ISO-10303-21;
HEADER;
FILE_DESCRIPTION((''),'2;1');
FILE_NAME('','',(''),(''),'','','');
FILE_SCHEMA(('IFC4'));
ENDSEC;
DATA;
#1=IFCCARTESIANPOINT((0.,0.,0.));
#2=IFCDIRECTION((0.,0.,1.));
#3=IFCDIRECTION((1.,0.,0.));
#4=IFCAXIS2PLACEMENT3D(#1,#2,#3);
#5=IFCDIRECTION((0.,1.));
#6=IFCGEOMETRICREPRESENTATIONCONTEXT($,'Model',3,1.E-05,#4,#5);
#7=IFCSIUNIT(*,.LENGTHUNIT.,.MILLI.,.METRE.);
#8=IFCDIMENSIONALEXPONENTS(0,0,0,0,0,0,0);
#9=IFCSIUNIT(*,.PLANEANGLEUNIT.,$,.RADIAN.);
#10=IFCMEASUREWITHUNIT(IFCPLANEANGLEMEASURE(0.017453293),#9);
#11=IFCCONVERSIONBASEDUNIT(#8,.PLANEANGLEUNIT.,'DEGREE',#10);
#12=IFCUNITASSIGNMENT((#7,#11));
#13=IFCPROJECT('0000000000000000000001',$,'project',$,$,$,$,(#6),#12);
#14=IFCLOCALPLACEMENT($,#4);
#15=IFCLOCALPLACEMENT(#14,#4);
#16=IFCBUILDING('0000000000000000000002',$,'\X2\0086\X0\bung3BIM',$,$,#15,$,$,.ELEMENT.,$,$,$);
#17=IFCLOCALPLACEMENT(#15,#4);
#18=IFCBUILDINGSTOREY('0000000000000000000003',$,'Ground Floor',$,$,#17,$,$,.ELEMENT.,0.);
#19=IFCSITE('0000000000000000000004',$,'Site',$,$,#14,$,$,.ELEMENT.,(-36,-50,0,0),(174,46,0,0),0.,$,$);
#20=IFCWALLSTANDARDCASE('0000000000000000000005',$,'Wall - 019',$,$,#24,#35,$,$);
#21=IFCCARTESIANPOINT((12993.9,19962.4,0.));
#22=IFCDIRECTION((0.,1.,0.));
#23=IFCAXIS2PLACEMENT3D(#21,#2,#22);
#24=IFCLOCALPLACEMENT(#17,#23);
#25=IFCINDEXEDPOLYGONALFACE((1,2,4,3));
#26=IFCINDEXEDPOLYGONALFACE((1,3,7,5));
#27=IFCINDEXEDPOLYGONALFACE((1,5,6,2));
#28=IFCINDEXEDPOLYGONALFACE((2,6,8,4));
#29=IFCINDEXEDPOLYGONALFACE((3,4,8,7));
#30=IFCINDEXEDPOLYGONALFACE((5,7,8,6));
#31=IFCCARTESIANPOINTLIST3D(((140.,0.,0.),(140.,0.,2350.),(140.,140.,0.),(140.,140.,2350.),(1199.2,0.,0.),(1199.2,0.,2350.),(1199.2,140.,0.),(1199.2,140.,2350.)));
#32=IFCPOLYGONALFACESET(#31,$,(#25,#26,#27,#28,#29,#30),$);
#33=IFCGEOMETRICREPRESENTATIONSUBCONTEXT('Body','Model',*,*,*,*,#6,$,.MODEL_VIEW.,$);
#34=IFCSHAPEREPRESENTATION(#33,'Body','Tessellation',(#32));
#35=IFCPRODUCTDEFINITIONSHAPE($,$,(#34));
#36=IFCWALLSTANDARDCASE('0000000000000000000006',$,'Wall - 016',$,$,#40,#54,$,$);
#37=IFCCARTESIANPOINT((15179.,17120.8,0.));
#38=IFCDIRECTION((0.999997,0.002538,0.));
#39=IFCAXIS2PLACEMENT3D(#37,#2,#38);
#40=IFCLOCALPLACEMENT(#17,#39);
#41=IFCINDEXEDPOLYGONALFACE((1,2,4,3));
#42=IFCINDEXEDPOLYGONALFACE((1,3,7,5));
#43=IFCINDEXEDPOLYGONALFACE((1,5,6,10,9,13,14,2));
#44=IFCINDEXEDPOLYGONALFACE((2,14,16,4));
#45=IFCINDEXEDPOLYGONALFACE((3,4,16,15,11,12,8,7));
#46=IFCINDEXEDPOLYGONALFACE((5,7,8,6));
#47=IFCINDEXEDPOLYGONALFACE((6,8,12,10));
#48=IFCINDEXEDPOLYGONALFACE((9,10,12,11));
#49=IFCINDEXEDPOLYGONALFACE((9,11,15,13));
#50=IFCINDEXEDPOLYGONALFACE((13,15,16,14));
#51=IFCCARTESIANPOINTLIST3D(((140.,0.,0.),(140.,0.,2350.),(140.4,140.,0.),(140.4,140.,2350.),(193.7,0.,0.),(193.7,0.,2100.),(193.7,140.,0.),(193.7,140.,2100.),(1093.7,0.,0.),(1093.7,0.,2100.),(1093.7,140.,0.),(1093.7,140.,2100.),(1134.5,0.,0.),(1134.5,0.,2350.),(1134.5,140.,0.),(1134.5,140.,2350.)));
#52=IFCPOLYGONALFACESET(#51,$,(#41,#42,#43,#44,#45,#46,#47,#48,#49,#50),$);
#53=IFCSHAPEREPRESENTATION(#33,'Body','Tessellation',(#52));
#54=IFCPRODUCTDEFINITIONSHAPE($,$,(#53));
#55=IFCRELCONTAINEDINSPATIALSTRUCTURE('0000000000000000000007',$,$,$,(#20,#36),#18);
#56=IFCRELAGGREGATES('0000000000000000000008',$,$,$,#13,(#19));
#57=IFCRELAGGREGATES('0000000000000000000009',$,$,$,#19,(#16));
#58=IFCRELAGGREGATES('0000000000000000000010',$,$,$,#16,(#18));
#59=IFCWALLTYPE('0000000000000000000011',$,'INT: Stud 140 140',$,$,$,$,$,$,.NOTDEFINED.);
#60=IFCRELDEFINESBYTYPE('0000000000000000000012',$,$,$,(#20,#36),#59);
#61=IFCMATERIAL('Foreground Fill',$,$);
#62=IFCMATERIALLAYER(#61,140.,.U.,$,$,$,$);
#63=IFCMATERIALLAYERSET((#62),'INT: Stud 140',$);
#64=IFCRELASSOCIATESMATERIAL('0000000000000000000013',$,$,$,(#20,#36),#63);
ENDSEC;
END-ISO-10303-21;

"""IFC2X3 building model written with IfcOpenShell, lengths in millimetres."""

from ifc_helpers import new_model, entity, si_unit, converted_unit, direction, frame, origin_with_axes, origin_2d_with_axis, place, context, subcontext, project, spatial, polyline, rectangle, outline, extrude, material, layer, layer_set, layer_usage, type_object, element, save


model = new_model("IFC2X3")

# Units and contexts
model_context = context("Model", 3, precision=1e-05, world=origin_with_axes(), true_north=direction((0.0, 1.0)))
body_context = subcontext(model_context, "Body", "Model", "MODEL_VIEW")
ifc_project = project(units=[si_unit("LENGTHUNIT", "METRE", prefix="MILLI"), converted_unit("PLANEANGLEUNIT", "DEGREE", entity("IfcPlaneAngleMeasure", 0.017453293), si_unit("PLANEANGLEUNIT", "RADIAN"), dimensions=[0, 0, 0, 0, 0, 0, 0])], contexts=[model_context])

# Site, building, storey
site_placement = place(None, origin_with_axes())
site = spatial("IfcSite", under=ifc_project, at=site_placement, Name="Site", CompositionType="ELEMENT", RefLatitude=(-36, -50, 0, 0), RefLongitude=(174, 46, 0, 0), RefElevation=0.0)
building_placement = place(site_placement, origin_with_axes())
building = spatial("IfcBuilding", under=site, at=building_placement, Name="\u0086bung3BIM", CompositionType="ELEMENT")
storey_placement = place(building_placement, origin_with_axes())
storey = spatial("IfcBuildingStorey", under=building, at=storey_placement, Name="Ground Floor", CompositionType="ELEMENT", Elevation=0.0)

# Shared definitions
ifc_material_1 = material(Name="Foreground Fill")
ifc_layer_1 = layer(ifc_material_1, 140.0, ventilated="UNKNOWN")
ifc_layer_set_1 = layer_set([ifc_layer_1], Name="INT: Stud 140")
wall_type_1 = type_object("IfcWallType", Name="INT: Stud 140 140", PredefinedType="NOTDEFINED")

# Wall
ifc_layer_usage_1 = layer_usage(ifc_layer_set_1, "AXIS2", "POSITIVE", 0.0)
wall_1_placement = place(storey_placement, frame((12993.9, 19962.4, 0.0), z_axis=(0.0, 0.0, 1.0), x_axis=(0.0, 1.0, 0.0)))
element("IfcWallStandardCase", 1, at=wall_1_placement, inside=storey, type_object=wall_type_1, material=ifc_layer_usage_1, Name="Wall - 019", context=body_context, shape_type="SweptSolid", body=[
    extrude(outline(polyline([(140.0, 0.0), (1199.2, 0.0), (1199.2, 140.0), (140.0, 140.0), (140.0, 0.0)])), origin_with_axes(), (0.0, 0.0, 1.0), 2350.0),
])

# Wall, opening
ifc_layer_usage_2 = layer_usage(ifc_layer_set_1, "AXIS2", "POSITIVE", 0.0)
wall_2_placement = place(storey_placement, frame((15179.0, 17120.8, 0.0), z_axis=(0.0, 0.0, 1.0), x_axis=(0.999997, 0.002538, 0.0)))
wall_2 = element("IfcWallStandardCase", 2, at=wall_2_placement, inside=storey, type_object=wall_type_1, material=ifc_layer_usage_2, Name="Wall - 016", context=body_context, shape_type="SweptSolid", body=[
    extrude(outline(polyline([(140.0, 0.0), (1134.5, 0.0), (1134.5, 140.0), (140.4, 140.0), (140.0, 0.0)])), origin_with_axes(), (0.0, 0.0, 1.0), 2350.0),
])
opening_1_placement = place(wall_2_placement, frame((643.7, 0.0, 0.0), z_axis=(0.0, 0.0, 1.0), x_axis=(1.0, 0.0, 0.0)))
element("IfcOpeningElement", 3, at=opening_1_placement, cuts=wall_2, context=body_context, shape_type="SweptSolid", body=[
    extrude(rectangle(XDim=900.0, YDim=2100.0, at=origin_2d_with_axis()), frame((0.0, -140.0, 1050.0), z_axis=(0.0, 1.0, 0.0), x_axis=(1.0, 0.0, 0.0)), (0.0, 0.0, 1.0), 420.0),
])

save(model, "model.ifc")
